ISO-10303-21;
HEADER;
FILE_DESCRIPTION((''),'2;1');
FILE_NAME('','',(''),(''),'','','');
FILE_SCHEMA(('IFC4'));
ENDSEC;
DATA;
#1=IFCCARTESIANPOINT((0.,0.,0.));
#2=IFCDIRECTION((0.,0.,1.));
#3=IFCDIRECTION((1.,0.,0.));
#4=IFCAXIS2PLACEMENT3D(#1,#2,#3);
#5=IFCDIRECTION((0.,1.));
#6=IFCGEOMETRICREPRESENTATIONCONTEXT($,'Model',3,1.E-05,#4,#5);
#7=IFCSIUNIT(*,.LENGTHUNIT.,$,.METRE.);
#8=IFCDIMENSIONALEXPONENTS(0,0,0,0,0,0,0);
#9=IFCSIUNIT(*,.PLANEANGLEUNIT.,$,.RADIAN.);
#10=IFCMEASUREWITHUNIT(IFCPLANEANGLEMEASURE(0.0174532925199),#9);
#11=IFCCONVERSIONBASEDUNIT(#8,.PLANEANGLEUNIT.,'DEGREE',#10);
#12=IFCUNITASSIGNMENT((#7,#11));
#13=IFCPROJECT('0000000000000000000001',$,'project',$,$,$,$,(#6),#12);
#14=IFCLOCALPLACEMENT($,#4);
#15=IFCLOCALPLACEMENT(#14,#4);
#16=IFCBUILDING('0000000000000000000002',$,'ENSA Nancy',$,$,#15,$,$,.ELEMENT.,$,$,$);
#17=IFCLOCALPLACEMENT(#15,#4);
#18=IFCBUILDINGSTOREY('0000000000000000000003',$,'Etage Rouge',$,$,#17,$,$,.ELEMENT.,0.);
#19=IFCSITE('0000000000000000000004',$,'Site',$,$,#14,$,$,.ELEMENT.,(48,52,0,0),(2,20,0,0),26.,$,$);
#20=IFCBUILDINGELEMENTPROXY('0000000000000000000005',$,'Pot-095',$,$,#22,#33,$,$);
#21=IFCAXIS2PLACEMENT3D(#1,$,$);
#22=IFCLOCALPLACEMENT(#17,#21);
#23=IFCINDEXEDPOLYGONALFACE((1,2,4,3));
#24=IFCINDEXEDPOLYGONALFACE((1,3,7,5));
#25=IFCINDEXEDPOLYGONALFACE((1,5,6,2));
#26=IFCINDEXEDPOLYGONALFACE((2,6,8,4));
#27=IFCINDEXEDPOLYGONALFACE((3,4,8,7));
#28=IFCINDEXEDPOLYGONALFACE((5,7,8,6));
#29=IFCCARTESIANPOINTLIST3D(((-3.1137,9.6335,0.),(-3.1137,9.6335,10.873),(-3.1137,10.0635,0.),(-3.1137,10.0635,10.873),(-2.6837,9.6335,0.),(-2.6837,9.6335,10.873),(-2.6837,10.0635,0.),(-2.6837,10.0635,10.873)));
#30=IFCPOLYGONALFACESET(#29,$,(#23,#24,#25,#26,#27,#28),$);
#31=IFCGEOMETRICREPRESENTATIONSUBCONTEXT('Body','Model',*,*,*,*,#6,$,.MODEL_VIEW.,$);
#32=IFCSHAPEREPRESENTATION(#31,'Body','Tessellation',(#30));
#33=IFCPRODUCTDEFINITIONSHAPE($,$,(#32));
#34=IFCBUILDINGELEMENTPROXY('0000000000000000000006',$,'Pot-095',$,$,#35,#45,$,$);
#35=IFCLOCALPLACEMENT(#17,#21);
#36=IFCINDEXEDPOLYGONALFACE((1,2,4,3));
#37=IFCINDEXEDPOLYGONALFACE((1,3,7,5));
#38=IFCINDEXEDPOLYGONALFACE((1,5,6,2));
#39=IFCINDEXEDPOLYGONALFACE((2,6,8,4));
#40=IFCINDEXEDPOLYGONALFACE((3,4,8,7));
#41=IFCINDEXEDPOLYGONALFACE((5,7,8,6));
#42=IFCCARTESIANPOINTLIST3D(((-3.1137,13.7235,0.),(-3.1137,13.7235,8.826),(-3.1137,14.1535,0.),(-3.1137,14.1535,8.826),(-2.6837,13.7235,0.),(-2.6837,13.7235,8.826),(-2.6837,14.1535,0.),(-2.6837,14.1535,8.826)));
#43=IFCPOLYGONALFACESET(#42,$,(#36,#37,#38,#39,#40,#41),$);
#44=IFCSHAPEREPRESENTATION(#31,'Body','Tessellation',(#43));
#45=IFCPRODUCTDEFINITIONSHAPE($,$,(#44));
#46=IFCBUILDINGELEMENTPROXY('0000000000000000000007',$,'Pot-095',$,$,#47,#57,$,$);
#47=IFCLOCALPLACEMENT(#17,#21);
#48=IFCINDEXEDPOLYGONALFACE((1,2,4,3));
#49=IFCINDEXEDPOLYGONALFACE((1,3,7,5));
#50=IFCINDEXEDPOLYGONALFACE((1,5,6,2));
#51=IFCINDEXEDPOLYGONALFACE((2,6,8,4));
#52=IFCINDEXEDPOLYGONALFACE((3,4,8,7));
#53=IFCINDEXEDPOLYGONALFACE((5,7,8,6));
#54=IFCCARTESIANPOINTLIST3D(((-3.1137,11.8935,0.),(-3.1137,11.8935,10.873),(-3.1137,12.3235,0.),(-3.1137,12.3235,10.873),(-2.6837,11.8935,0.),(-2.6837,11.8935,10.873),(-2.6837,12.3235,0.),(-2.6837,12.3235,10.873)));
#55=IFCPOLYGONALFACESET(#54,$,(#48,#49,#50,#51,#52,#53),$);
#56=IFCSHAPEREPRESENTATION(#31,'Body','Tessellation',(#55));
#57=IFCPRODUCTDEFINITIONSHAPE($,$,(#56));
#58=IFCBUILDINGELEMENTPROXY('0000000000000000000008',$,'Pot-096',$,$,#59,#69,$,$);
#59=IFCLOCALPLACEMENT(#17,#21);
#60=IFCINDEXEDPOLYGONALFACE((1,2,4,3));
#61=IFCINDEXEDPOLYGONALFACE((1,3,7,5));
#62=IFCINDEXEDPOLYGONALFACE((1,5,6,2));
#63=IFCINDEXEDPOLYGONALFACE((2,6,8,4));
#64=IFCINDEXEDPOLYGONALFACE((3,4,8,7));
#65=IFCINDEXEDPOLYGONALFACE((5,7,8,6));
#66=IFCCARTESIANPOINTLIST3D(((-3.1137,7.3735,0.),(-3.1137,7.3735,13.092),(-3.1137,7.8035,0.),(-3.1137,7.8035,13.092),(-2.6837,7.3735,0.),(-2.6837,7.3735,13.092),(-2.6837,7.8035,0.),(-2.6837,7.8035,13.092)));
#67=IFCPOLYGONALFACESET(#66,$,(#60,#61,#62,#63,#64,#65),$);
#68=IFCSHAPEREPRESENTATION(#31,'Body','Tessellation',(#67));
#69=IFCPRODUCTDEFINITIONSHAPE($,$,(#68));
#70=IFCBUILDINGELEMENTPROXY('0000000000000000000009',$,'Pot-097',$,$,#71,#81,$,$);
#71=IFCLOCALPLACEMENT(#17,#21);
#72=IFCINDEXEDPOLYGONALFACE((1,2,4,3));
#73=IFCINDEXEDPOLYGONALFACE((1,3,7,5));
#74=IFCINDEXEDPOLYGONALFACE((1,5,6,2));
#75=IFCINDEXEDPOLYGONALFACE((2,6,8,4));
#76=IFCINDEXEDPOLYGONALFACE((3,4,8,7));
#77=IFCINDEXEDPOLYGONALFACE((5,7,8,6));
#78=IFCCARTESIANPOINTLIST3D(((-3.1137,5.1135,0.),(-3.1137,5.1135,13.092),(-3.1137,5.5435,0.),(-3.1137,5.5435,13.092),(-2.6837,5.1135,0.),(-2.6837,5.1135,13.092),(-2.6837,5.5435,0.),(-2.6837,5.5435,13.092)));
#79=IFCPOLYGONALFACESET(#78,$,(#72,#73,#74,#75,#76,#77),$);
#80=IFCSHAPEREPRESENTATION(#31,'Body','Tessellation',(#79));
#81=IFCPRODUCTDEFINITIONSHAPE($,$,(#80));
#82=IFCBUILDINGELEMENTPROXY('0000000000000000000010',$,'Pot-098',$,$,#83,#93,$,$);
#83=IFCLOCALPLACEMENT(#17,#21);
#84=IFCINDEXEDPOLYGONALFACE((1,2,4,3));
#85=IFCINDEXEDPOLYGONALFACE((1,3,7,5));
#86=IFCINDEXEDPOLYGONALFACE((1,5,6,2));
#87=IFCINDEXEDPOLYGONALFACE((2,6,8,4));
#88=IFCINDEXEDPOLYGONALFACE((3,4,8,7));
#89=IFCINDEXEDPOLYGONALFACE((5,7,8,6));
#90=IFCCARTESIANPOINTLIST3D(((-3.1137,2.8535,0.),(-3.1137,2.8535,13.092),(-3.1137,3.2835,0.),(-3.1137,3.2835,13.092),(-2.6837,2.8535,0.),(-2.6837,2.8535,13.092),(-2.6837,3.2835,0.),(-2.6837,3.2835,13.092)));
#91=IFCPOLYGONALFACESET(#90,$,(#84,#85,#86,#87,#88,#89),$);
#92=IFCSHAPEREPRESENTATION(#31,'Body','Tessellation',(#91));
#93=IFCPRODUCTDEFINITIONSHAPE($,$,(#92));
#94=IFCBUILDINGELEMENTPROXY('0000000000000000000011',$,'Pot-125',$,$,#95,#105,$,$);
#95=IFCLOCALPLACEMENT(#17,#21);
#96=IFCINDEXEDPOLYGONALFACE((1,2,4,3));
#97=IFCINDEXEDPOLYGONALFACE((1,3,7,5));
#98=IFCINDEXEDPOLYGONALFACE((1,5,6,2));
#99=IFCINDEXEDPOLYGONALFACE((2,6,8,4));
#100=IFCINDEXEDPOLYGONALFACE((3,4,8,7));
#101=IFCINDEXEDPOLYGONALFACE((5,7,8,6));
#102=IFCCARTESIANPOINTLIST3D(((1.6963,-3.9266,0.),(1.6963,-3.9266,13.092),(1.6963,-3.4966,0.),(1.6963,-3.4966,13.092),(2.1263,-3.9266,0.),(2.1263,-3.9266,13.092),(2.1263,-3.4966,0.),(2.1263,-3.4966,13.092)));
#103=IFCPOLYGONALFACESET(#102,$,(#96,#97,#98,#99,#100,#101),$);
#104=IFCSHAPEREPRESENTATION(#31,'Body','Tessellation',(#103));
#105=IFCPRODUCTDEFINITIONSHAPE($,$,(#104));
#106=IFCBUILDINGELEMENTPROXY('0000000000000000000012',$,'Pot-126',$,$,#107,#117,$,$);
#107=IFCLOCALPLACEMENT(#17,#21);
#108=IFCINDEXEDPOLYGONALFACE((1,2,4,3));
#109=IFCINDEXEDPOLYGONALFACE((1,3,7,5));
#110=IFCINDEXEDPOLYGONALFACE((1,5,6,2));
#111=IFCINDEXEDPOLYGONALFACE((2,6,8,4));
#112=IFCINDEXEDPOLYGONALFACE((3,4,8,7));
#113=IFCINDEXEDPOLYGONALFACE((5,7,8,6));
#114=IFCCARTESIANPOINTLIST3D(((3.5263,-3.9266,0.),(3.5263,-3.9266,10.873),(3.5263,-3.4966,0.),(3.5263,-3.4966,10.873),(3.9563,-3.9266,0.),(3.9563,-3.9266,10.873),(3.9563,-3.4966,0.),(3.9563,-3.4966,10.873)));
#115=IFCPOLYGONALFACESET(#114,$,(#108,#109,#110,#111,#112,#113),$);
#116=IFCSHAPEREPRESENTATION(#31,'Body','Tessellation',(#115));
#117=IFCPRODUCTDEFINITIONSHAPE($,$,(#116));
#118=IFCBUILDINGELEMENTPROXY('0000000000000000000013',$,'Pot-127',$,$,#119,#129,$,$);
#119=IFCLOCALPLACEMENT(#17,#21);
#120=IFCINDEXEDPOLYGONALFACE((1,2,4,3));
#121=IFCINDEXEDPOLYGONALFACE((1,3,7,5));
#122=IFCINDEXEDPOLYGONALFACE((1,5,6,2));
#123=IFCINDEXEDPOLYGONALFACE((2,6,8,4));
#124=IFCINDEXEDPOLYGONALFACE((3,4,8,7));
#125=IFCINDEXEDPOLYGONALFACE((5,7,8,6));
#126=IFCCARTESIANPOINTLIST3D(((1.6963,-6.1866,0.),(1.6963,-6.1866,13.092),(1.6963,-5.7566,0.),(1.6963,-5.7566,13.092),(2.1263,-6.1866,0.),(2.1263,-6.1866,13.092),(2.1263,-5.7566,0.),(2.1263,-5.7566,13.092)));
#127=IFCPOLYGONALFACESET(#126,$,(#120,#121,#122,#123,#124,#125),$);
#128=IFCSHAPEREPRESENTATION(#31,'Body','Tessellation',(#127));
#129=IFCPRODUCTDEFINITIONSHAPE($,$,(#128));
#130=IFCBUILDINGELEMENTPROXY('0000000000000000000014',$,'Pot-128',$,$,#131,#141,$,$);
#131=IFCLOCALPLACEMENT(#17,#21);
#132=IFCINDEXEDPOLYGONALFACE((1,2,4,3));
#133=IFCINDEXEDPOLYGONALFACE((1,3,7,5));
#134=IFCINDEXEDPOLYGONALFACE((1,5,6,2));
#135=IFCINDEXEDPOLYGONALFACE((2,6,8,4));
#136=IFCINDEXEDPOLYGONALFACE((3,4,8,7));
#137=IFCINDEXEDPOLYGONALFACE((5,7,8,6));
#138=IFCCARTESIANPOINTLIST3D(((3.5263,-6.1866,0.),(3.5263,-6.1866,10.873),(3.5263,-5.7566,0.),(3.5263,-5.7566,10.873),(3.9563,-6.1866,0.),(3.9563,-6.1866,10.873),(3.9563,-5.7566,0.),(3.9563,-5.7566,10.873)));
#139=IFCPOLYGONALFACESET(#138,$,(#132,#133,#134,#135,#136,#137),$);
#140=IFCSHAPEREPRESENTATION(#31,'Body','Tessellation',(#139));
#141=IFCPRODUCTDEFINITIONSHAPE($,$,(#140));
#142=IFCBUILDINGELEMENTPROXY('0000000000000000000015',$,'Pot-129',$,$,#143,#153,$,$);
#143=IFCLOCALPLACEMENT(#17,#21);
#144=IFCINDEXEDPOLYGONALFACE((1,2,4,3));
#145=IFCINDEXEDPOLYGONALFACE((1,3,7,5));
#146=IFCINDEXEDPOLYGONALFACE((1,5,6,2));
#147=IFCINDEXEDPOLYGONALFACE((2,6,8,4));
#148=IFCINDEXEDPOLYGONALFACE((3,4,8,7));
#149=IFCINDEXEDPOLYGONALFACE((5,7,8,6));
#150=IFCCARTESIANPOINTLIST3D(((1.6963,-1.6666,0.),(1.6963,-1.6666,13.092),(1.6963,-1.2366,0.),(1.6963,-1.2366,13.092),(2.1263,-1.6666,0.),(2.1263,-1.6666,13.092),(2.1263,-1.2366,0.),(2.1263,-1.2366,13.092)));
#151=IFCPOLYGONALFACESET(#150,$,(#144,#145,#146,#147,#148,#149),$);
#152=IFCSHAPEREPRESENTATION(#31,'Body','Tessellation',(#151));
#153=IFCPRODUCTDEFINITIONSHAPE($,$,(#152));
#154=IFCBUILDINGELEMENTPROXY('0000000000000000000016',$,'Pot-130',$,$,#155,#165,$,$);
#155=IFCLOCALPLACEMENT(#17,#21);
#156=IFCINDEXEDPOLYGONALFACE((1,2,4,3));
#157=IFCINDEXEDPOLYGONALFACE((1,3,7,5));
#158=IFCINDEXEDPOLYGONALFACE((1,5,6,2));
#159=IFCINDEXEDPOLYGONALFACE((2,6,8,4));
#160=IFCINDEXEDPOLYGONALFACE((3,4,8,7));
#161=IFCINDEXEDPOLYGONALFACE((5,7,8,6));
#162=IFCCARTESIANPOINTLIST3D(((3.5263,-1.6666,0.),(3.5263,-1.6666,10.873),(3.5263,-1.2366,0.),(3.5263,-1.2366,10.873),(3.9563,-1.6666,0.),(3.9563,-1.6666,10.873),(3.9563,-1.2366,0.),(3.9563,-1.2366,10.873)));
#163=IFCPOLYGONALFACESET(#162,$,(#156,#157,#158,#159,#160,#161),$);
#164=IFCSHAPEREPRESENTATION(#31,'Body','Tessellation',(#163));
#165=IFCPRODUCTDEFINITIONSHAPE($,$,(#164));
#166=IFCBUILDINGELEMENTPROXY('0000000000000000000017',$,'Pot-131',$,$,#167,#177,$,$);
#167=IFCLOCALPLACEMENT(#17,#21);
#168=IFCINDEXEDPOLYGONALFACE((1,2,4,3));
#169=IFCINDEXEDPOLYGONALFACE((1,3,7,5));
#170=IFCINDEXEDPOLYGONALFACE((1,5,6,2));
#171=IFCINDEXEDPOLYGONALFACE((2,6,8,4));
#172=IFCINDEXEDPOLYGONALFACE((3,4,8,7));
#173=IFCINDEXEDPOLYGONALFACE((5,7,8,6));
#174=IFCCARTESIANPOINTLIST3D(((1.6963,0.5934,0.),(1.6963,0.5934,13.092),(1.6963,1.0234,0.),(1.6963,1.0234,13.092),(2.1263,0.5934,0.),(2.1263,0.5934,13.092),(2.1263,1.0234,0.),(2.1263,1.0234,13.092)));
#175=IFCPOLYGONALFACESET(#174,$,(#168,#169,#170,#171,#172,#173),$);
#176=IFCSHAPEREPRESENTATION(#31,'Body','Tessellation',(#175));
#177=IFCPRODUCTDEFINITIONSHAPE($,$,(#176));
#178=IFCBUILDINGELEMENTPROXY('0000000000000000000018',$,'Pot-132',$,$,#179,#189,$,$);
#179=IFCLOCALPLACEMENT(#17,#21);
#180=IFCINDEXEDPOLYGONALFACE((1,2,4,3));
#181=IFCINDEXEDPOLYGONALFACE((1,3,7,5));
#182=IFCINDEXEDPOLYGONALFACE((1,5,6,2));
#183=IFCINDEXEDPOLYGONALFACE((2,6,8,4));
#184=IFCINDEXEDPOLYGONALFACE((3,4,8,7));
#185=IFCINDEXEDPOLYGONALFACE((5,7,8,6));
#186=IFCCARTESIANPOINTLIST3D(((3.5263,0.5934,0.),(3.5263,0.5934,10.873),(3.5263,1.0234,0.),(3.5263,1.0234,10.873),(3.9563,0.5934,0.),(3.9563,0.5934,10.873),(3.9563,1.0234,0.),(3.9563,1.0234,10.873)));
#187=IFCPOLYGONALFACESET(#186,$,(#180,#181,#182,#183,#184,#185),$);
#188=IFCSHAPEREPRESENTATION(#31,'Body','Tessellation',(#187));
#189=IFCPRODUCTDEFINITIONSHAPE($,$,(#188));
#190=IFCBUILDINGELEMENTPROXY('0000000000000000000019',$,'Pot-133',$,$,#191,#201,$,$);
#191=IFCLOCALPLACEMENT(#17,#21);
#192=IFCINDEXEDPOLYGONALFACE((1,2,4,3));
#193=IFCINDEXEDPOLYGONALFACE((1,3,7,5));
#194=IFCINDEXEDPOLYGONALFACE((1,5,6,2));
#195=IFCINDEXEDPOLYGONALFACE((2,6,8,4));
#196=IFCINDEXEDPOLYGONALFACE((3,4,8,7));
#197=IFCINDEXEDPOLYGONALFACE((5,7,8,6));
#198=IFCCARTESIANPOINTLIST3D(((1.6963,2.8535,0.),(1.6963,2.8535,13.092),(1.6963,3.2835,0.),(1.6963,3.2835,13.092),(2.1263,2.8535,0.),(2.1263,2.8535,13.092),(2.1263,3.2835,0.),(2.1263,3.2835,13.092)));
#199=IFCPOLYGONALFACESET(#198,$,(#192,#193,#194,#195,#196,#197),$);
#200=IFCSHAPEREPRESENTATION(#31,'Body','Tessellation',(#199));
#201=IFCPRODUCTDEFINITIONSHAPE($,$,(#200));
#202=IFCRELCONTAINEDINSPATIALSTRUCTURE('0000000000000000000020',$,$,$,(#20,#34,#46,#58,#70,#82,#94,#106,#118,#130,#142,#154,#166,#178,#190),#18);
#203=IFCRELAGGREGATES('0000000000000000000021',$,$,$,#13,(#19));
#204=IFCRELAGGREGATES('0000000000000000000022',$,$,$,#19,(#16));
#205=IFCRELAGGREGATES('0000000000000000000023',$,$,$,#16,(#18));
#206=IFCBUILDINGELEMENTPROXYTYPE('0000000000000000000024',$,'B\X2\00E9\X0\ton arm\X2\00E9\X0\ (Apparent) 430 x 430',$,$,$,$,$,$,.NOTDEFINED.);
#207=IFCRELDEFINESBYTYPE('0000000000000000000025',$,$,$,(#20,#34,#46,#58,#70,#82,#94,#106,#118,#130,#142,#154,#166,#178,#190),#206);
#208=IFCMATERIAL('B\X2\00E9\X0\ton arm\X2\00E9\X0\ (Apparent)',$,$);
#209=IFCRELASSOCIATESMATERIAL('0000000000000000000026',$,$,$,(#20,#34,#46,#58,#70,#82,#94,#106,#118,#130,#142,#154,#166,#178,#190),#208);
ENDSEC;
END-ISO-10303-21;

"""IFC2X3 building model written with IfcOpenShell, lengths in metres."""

from ifc_helpers import new_model, entity, si_unit, converted_unit, direction, frame, origin_with_axes, origin_2d_with_axis, place, context, subcontext, project, spatial, rectangle, extrude, material, type_object, element, save


model = new_model("IFC2X3")

# Units and contexts
model_context = context("Model", 3, precision=1e-05, world=origin_with_axes(), true_north=direction((0.0, 1.0)))
body_context = subcontext(model_context, "Body", "Model", "MODEL_VIEW")
ifc_project = project(units=[si_unit("LENGTHUNIT", "METRE"), converted_unit("PLANEANGLEUNIT", "DEGREE", entity("IfcPlaneAngleMeasure", 0.0174532925199), si_unit("PLANEANGLEUNIT", "RADIAN"), dimensions=[0, 0, 0, 0, 0, 0, 0])], contexts=[model_context])

# Site, building, storey
site_placement = place(None, origin_with_axes())
site = spatial("IfcSite", under=ifc_project, at=site_placement, Name="Site", CompositionType="ELEMENT", RefLatitude=(48, 52, 0, 0), RefLongitude=(2, 20, 0, 0), RefElevation=26.0)
building_placement = place(site_placement, origin_with_axes())
building = spatial("IfcBuilding", under=site, at=building_placement, Name="ENSA Nancy", CompositionType="ELEMENT")
storey_placement = place(building_placement, origin_with_axes())
storey = spatial("IfcBuildingStorey", under=building, at=storey_placement, Name="Etage Rouge", CompositionType="ELEMENT", Elevation=0.0)

# Building element proxies
ifc_material_1 = material(Name="Béton armé (Apparent)")
building_element_proxy_type_1 = type_object("IfcBuildingElementProxyType", Name="Béton armé (Apparent) 430 x 430", PredefinedType="NOTDEFINED")
proxy_1_placement = place(storey_placement, frame((-2.8987, 9.8485, 0.0), z_axis=(0.0, 0.0, 1.0), x_axis=(1.0, 0.0, 0.0)))
element("IfcBuildingElementProxy", 1, at=proxy_1_placement, inside=storey, type_object=building_element_proxy_type_1, material=ifc_material_1, Name="Pot-095", context=body_context, shape_type="SweptSolid", body=[
    extrude(rectangle(XDim=0.43, YDim=0.43, at=origin_2d_with_axis()), origin_with_axes(), (0.0, 0.0, 1.0), 10.873),
])
proxy_2_placement = place(storey_placement, frame((-2.8987, 13.9385, 0.0), z_axis=(0.0, 0.0, 1.0), x_axis=(1.0, 0.0, 0.0)))
element("IfcBuildingElementProxy", 2, at=proxy_2_placement, inside=storey, type_object=building_element_proxy_type_1, material=ifc_material_1, Name="Pot-095", context=body_context, shape_type="SweptSolid", body=[
    extrude(rectangle(XDim=0.43, YDim=0.43, at=origin_2d_with_axis()), origin_with_axes(), (0.0, 0.0, 1.0), 8.826),
])
proxy_3_placement = place(storey_placement, frame((-2.8987, 12.1085, 0.0), z_axis=(0.0, 0.0, 1.0), x_axis=(1.0, 0.0, 0.0)))
element("IfcBuildingElementProxy", 3, at=proxy_3_placement, inside=storey, type_object=building_element_proxy_type_1, material=ifc_material_1, Name="Pot-095", context=body_context, shape_type="SweptSolid", body=[
    extrude(rectangle(XDim=0.43, YDim=0.43, at=origin_2d_with_axis()), origin_with_axes(), (0.0, 0.0, 1.0), 10.873),
])
for number, where, z_axis, x_axis, name in (
    (4, (-2.8987, 7.5885, 0.0), (0.0, 0.0, 1.0), (1.0, 0.0, 0.0), "Pot-096"),
    (5, (-2.8987, 5.3285, 0.0), (0.0, 0.0, 1.0), (1.0, 0.0, 0.0), "Pot-097"),
    (6, (-2.8987, 3.0685, 0.0), (0.0, 0.0, 1.0), (1.0, 0.0, 0.0), "Pot-098"),
    (7, (1.9113, -3.7116, 0.0), (0.0, 0.0, 1.0), (1.0, 0.0, 0.0), "Pot-125"),
):
    element("IfcBuildingElementProxy", number, at=place(storey_placement, frame(where, z_axis=z_axis, x_axis=x_axis)), inside=storey, type_object=building_element_proxy_type_1, material=ifc_material_1, Name=name, context=body_context, shape_type="SweptSolid", body=[
        extrude(rectangle(XDim=0.43, YDim=0.43, at=origin_2d_with_axis()), origin_with_axes(), (0.0, 0.0, 1.0), 13.092),
    ])
proxy_4_placement = place(storey_placement, frame((3.7413, -3.7116, 0.0), z_axis=(0.0, 0.0, 1.0), x_axis=(1.0, 0.0, 0.0)))
element("IfcBuildingElementProxy", 8, at=proxy_4_placement, inside=storey, type_object=building_element_proxy_type_1, material=ifc_material_1, Name="Pot-126", context=body_context, shape_type="SweptSolid", body=[
    extrude(rectangle(XDim=0.43, YDim=0.43, at=origin_2d_with_axis()), origin_with_axes(), (0.0, 0.0, 1.0), 10.873),
])
proxy_5_placement = place(storey_placement, frame((1.9113, -5.9716, 0.0), z_axis=(0.0, 0.0, 1.0), x_axis=(1.0, 0.0, 0.0)))
element("IfcBuildingElementProxy", 9, at=proxy_5_placement, inside=storey, type_object=building_element_proxy_type_1, material=ifc_material_1, Name="Pot-127", context=body_context, shape_type="SweptSolid", body=[
    extrude(rectangle(XDim=0.43, YDim=0.43, at=origin_2d_with_axis()), origin_with_axes(), (0.0, 0.0, 1.0), 13.092),
])
proxy_6_placement = place(storey_placement, frame((3.7413, -5.9716, 0.0), z_axis=(0.0, 0.0, 1.0), x_axis=(1.0, 0.0, 0.0)))
element("IfcBuildingElementProxy", 10, at=proxy_6_placement, inside=storey, type_object=building_element_proxy_type_1, material=ifc_material_1, Name="Pot-128", context=body_context, shape_type="SweptSolid", body=[
    extrude(rectangle(XDim=0.43, YDim=0.43, at=origin_2d_with_axis()), origin_with_axes(), (0.0, 0.0, 1.0), 10.873),
])
proxy_7_placement = place(storey_placement, frame((1.9113, -1.4516, 0.0), z_axis=(0.0, 0.0, 1.0), x_axis=(1.0, 0.0, 0.0)))
element("IfcBuildingElementProxy", 11, at=proxy_7_placement, inside=storey, type_object=building_element_proxy_type_1, material=ifc_material_1, Name="Pot-129", context=body_context, shape_type="SweptSolid", body=[
    extrude(rectangle(XDim=0.43, YDim=0.43, at=origin_2d_with_axis()), origin_with_axes(), (0.0, 0.0, 1.0), 13.092),
])
proxy_8_placement = place(storey_placement, frame((3.7413, -1.4516, 0.0), z_axis=(0.0, 0.0, 1.0), x_axis=(1.0, 0.0, 0.0)))
element("IfcBuildingElementProxy", 12, at=proxy_8_placement, inside=storey, type_object=building_element_proxy_type_1, material=ifc_material_1, Name="Pot-130", context=body_context, shape_type="SweptSolid", body=[
    extrude(rectangle(XDim=0.43, YDim=0.43, at=origin_2d_with_axis()), origin_with_axes(), (0.0, 0.0, 1.0), 10.873),
])
proxy_9_placement = place(storey_placement, frame((1.9113, 0.8084, 0.0), z_axis=(0.0, 0.0, 1.0), x_axis=(1.0, 0.0, 0.0)))
element("IfcBuildingElementProxy", 13, at=proxy_9_placement, inside=storey, type_object=building_element_proxy_type_1, material=ifc_material_1, Name="Pot-131", context=body_context, shape_type="SweptSolid", body=[
    extrude(rectangle(XDim=0.43, YDim=0.43, at=origin_2d_with_axis()), origin_with_axes(), (0.0, 0.0, 1.0), 13.092),
])
proxy_10_placement = place(storey_placement, frame((3.7413, 0.8084, 0.0), z_axis=(0.0, 0.0, 1.0), x_axis=(1.0, 0.0, 0.0)))
element("IfcBuildingElementProxy", 14, at=proxy_10_placement, inside=storey, type_object=building_element_proxy_type_1, material=ifc_material_1, Name="Pot-132", context=body_context, shape_type="SweptSolid", body=[
    extrude(rectangle(XDim=0.43, YDim=0.43, at=origin_2d_with_axis()), origin_with_axes(), (0.0, 0.0, 1.0), 10.873),
])
proxy_11_placement = place(storey_placement, frame((1.9113, 3.0685, 0.0), z_axis=(0.0, 0.0, 1.0), x_axis=(1.0, 0.0, 0.0)))
element("IfcBuildingElementProxy", 15, at=proxy_11_placement, inside=storey, type_object=building_element_proxy_type_1, material=ifc_material_1, Name="Pot-133", context=body_context, shape_type="SweptSolid", body=[
    extrude(rectangle(XDim=0.43, YDim=0.43, at=origin_2d_with_axis()), origin_with_axes(), (0.0, 0.0, 1.0), 13.092),
])

save(model, "model.ifc")
